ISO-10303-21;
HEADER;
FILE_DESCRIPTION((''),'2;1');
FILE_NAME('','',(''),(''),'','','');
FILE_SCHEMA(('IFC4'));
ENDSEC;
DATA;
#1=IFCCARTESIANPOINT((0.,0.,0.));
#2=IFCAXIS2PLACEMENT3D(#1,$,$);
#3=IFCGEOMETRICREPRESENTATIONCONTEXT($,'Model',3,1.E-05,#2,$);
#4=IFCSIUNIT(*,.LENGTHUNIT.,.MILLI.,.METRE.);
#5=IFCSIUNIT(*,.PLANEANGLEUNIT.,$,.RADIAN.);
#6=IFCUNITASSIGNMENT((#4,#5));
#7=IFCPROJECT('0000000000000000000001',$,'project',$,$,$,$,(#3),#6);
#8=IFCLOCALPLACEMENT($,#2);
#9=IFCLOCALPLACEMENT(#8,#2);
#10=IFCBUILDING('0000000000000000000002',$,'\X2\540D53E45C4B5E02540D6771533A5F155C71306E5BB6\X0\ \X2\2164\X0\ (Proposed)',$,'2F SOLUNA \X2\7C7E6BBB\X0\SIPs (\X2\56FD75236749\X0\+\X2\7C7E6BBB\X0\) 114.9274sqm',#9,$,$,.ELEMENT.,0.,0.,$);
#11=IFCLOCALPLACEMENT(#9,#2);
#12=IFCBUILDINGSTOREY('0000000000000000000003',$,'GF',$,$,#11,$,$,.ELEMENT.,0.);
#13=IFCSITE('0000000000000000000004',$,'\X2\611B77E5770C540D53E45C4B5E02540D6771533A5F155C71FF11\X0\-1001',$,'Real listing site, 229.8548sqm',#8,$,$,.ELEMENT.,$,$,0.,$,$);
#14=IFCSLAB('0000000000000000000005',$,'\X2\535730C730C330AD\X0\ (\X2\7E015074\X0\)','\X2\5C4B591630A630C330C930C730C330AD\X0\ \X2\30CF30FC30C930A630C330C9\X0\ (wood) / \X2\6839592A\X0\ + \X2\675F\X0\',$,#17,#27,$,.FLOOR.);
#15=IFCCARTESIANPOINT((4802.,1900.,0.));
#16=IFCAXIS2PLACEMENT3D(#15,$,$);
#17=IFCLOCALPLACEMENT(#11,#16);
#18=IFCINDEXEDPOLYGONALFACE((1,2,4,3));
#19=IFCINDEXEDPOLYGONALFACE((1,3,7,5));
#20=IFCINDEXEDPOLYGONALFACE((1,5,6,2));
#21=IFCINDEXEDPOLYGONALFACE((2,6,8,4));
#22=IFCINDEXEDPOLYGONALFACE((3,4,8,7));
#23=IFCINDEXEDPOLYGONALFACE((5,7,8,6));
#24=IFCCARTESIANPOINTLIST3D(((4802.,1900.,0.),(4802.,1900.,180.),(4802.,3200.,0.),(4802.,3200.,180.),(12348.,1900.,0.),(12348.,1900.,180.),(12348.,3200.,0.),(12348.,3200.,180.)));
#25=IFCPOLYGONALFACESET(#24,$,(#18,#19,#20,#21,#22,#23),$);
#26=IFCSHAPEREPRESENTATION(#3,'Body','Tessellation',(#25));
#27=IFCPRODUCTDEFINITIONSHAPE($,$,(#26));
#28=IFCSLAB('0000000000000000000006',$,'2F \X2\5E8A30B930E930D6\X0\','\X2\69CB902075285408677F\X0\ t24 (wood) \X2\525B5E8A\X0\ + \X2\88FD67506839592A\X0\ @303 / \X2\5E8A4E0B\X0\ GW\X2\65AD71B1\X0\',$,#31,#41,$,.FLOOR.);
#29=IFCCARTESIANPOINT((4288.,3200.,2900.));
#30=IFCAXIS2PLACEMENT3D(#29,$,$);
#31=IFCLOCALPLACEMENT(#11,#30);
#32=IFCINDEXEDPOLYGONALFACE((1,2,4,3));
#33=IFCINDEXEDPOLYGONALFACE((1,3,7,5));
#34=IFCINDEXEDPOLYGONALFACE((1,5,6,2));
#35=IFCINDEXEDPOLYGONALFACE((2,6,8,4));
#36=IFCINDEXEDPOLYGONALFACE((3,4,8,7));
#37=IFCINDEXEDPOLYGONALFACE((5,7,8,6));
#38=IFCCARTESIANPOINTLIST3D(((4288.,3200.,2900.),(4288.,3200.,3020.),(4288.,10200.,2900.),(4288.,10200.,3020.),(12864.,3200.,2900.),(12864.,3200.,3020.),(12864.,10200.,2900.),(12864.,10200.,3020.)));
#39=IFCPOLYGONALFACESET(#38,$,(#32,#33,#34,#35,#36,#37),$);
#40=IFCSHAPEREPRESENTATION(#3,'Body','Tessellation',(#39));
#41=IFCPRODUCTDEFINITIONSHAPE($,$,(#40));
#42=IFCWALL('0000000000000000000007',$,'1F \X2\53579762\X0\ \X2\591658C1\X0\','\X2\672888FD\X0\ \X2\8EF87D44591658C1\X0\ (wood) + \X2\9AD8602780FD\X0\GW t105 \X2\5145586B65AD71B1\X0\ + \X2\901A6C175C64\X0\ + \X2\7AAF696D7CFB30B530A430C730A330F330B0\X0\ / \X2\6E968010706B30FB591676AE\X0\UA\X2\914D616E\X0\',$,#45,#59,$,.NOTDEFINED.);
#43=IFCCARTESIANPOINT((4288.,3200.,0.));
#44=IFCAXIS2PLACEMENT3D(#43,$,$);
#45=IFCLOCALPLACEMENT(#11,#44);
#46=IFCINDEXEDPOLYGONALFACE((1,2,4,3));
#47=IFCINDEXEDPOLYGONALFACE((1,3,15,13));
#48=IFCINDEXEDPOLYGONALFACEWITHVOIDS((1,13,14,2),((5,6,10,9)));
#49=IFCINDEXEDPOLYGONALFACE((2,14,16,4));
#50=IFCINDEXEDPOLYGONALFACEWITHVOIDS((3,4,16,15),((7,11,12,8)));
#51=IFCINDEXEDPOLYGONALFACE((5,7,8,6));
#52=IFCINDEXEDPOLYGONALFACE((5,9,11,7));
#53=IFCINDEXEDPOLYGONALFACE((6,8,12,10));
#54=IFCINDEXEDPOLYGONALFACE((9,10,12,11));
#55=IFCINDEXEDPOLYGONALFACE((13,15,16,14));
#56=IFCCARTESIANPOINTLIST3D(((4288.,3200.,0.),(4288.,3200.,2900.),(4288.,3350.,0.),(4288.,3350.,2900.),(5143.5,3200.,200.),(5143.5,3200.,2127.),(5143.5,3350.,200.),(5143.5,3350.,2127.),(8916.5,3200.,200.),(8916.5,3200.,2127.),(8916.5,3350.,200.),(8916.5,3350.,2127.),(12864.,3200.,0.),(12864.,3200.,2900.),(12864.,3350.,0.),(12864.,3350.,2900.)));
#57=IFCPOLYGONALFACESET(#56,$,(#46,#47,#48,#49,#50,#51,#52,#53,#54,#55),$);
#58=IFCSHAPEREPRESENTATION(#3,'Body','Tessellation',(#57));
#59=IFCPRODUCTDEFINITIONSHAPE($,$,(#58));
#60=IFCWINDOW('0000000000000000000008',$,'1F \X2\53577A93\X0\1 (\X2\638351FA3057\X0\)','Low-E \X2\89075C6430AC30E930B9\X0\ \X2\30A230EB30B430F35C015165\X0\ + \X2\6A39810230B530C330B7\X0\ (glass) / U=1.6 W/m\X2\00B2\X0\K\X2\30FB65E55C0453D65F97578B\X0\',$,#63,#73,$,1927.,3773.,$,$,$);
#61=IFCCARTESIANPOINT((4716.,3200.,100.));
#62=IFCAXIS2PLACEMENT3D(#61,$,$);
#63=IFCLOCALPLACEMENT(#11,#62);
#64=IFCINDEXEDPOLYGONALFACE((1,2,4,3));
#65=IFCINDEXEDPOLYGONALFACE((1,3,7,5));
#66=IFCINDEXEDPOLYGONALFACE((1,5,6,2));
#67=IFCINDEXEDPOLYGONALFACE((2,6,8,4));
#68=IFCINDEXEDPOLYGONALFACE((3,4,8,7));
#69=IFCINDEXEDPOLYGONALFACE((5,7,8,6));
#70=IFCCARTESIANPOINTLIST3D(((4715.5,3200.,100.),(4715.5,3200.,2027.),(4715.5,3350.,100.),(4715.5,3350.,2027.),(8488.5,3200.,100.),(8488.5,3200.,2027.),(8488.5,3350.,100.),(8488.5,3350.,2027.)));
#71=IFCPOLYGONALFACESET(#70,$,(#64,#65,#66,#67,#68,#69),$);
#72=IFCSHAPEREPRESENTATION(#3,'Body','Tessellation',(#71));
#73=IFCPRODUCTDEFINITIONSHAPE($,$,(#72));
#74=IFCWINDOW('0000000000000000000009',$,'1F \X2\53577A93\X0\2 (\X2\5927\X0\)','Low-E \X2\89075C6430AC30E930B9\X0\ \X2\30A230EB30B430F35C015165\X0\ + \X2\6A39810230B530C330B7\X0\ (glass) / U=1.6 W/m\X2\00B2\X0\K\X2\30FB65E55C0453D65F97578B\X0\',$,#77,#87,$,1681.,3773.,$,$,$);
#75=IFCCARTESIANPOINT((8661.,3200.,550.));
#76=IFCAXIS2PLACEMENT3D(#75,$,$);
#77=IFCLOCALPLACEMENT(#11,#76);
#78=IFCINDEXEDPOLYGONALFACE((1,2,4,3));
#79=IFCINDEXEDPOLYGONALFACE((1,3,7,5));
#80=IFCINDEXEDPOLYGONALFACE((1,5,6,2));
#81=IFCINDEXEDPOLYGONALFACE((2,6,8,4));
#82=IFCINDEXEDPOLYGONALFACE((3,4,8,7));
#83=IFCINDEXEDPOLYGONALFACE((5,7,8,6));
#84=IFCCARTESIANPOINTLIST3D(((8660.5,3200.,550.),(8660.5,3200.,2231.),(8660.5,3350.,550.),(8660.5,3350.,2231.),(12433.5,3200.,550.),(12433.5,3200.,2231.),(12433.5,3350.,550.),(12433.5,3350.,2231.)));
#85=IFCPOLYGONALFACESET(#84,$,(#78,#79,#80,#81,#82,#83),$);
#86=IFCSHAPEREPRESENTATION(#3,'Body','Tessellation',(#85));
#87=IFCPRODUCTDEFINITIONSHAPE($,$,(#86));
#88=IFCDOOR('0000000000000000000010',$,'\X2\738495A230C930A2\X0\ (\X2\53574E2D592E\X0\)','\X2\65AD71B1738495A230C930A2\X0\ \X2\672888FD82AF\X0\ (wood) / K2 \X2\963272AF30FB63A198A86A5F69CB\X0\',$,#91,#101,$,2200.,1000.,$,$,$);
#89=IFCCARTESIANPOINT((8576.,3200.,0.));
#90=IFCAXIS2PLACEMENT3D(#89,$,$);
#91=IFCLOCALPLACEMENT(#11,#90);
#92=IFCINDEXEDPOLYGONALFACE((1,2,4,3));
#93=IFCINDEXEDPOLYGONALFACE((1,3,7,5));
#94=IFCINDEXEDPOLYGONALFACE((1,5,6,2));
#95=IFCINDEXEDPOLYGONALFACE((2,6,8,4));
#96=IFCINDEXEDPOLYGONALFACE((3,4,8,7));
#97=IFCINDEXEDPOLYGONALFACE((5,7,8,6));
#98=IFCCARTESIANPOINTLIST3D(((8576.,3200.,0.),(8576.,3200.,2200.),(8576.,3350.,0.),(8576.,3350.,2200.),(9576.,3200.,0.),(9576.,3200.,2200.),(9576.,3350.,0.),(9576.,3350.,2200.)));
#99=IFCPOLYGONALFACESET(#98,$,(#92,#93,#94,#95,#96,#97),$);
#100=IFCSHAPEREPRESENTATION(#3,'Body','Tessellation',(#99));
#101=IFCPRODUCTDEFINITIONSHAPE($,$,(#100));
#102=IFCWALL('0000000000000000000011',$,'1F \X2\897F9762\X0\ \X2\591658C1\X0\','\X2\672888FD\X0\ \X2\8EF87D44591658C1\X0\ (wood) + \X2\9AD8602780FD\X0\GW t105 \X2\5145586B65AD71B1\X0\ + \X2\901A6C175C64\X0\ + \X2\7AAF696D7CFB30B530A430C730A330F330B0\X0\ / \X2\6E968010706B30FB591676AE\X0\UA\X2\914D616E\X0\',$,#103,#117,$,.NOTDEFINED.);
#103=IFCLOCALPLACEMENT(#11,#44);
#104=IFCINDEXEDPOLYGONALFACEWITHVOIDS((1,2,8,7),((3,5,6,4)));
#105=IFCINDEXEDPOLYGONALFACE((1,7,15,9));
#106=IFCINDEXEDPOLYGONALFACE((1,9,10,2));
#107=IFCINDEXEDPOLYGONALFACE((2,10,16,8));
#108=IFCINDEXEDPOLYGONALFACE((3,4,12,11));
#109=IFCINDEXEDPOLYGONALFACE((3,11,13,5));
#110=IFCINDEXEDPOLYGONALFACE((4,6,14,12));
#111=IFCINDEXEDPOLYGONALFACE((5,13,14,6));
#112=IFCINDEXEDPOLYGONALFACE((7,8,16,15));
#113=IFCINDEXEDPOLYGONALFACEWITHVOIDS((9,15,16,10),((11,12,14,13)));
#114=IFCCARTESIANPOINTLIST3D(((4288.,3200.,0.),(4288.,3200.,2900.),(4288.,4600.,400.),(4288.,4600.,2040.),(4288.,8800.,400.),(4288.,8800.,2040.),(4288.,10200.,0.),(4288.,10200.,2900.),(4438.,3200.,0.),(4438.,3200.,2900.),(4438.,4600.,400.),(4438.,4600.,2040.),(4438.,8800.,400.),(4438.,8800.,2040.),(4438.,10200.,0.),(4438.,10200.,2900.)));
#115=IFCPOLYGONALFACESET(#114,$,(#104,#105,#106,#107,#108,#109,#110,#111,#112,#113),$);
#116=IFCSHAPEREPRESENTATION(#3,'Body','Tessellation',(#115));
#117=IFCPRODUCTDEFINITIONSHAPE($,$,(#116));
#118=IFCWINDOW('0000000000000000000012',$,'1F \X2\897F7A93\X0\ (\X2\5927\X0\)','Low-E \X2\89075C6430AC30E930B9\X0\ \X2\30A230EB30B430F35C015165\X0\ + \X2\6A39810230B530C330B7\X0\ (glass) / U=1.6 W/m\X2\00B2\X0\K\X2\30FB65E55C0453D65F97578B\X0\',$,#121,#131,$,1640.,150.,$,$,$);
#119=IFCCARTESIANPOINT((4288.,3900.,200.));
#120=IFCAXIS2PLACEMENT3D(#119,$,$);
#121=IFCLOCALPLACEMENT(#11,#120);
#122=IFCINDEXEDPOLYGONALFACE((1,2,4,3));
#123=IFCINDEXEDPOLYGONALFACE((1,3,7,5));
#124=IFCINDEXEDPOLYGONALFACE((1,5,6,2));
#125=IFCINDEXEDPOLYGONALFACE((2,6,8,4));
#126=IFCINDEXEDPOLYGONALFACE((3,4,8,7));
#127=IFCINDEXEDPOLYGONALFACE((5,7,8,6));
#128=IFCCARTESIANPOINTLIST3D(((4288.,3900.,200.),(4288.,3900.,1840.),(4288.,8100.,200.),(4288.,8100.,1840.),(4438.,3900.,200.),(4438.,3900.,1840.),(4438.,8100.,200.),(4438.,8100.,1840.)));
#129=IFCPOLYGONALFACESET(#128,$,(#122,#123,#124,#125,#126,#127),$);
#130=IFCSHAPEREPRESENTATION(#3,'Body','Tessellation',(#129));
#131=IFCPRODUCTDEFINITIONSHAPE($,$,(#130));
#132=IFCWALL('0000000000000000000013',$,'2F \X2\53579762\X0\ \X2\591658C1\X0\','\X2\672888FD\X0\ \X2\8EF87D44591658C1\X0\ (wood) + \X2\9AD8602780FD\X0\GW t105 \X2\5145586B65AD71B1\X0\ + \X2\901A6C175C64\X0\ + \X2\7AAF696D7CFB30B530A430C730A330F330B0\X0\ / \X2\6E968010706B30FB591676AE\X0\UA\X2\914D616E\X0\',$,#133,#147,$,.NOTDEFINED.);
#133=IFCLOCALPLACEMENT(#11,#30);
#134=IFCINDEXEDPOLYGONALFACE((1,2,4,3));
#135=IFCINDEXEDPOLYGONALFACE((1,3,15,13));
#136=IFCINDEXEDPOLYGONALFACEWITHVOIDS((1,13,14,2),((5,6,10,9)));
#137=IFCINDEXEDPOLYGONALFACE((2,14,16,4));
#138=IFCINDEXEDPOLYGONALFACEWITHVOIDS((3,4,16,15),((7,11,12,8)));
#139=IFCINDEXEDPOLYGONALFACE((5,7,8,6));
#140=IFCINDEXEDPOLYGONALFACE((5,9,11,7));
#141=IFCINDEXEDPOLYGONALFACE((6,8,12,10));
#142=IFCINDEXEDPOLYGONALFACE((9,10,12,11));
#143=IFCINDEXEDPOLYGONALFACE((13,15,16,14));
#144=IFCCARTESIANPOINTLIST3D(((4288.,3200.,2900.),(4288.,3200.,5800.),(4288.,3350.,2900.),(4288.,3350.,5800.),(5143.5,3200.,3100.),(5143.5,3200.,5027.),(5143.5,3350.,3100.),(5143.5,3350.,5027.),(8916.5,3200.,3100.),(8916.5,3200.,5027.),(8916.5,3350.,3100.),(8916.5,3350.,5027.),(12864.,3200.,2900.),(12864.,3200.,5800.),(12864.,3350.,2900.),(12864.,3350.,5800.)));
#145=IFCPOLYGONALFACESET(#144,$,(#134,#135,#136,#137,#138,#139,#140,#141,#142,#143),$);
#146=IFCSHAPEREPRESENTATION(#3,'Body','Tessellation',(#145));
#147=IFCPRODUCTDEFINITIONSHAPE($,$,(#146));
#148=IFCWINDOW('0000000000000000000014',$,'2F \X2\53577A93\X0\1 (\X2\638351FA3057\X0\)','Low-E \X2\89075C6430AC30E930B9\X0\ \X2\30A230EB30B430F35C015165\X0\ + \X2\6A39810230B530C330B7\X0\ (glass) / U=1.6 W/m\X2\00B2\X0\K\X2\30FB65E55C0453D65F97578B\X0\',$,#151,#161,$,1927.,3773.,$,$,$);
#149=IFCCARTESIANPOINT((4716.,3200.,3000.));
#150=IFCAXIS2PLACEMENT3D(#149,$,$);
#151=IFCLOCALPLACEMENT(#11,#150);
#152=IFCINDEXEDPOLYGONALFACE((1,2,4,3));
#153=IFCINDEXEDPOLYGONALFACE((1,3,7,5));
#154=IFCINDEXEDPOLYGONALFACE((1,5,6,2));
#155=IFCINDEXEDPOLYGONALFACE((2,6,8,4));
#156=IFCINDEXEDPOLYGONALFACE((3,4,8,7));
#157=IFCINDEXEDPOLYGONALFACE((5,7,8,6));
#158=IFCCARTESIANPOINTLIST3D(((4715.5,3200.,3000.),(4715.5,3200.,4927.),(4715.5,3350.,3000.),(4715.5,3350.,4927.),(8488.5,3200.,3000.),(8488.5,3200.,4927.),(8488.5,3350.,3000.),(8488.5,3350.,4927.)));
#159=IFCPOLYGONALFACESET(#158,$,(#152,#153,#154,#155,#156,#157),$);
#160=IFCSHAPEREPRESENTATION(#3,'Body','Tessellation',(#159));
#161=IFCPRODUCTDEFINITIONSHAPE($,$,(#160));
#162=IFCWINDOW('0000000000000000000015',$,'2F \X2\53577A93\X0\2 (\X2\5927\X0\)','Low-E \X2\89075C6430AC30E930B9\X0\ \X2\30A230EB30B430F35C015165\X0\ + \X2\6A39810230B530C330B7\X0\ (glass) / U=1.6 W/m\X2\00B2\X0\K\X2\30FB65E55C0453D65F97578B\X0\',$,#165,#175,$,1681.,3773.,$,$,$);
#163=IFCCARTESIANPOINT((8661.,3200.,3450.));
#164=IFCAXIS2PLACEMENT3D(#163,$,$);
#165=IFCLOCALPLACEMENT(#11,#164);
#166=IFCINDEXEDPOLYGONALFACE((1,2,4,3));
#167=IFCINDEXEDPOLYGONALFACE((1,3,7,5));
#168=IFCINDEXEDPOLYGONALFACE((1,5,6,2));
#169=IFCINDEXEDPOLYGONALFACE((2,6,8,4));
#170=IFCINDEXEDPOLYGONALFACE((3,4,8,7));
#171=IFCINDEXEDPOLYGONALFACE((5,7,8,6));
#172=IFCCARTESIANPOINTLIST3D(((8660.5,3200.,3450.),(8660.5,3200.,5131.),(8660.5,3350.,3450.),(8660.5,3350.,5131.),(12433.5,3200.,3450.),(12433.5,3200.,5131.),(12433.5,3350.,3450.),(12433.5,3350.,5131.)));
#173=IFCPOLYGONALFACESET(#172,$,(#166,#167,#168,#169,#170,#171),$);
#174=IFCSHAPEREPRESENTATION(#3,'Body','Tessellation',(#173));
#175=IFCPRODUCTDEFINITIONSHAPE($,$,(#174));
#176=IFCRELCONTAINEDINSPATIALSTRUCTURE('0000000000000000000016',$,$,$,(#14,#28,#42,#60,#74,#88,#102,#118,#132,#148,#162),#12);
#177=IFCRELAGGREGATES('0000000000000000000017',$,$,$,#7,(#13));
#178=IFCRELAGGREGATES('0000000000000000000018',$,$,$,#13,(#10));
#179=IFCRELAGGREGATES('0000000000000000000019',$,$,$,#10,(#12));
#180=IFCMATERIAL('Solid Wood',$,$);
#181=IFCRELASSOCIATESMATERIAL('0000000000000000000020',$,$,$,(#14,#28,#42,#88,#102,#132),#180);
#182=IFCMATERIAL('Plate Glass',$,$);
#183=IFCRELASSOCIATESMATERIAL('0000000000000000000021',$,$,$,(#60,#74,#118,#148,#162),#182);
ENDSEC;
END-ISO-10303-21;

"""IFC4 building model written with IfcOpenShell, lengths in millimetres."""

from ifc_helpers import new_model, si_unit, frame, frame_2d, origin, place, context, project, spatial, rectangle, extrude, material, element, fill, save


model = new_model("IFC4")

# Units and contexts
model_context = context("Model", 3, precision=1e-05, world=origin())
ifc_project = project(units=[si_unit("LENGTHUNIT", "METRE", prefix="MILLI"), si_unit("PLANEANGLEUNIT", "RADIAN")], contexts=[model_context])

# Site, building, storey
site_placement = place(None, origin())
site = spatial("IfcSite", under=ifc_project, at=site_placement, Name="愛知県名古屋市名東区引山１-1001", ObjectType="Real listing site, 229.8548sqm", CompositionType="ELEMENT", RefElevation=0.0)
building_placement = place(site_placement, origin())
building = spatial("IfcBuilding", under=site, at=building_placement, Name="名古屋市名東区引山の家 Ⅴ (Proposed)", ObjectType="2F SOLUNA 籾殻SIPs (国産杉+籾殻) 114.9274sqm", CompositionType="ELEMENT", ElevationOfRefHeight=0.0, ElevationOfTerrain=0.0)
storey_placement = place(building_placement, origin())
storey = spatial("IfcBuildingStorey", under=building, at=storey_placement, Name="GF", CompositionType="ELEMENT", Elevation=0.0)

# Slabs
ifc_material_1 = material(Name="Solid Wood")
slab_1_placement = place(storey_placement, frame((4802.0, 1900.0, 0.0)))
element("IfcSlab", 1, at=slab_1_placement, inside=storey, material=ifc_material_1, Name="南デッキ (縁側)", Description="屋外ウッドデッキ ハードウッド (wood) / 根太 + 束", PredefinedType="FLOOR", context=model_context, shape_type="SweptSolid", body=[
    extrude(rectangle(XDim=7546.0, YDim=1300.0, at=frame_2d((3773.0, 650.0))), frame((4802.0, 1900.0, 0.0)), (0.0, 0.0, 1.0), 180.0),
])
slab_2_placement = place(storey_placement, frame((4288.0, 3200.0, 2900.0)))
element("IfcSlab", 2, at=slab_2_placement, inside=storey, material=ifc_material_1, Name="2F 床スラブ", Description="構造用合板 t24 (wood) 剛床 + 製材根太 @303 / 床下 GW断熱", PredefinedType="FLOOR", context=model_context, shape_type="SweptSolid", body=[
    extrude(rectangle(XDim=8576.0, YDim=7000.0, at=frame_2d((4288.0, 3500.0))), frame((4288.0, 3200.0, 2900.0)), (0.0, 0.0, 1.0), 120.0),
])

# Wall, openings, windows, door
wall_1_placement = place(storey_placement, frame((4288.0, 3200.0, 0.0)))
wall_1 = element("IfcWall", 3, at=wall_1_placement, inside=storey, material=ifc_material_1, Name="1F 南面 外壁", Description="木製 軸組外壁 (wood) + 高性能GW t105 充填断熱 + 通気層 + 窯業系サイディング / 準耐火・外皮UA配慮", PredefinedType="NOTDEFINED", context=model_context, shape_type="SweptSolid", body=[
    extrude(rectangle(XDim=8576.0, YDim=150.0, at=frame_2d((4288.0, 75.0))), frame((4288.0, 3200.0, 0.0)), (0.0, 0.0, 1.0), 2900.0),
])
opening_1_placement = place(storey_placement, frame((4716.0, 3200.0, 100.0)))
opening_1 = element("IfcOpeningElement", 4, at=opening_1_placement, cuts=wall_1, PredefinedType="NOTDEFINED", context=model_context, shape_type="SweptSolid", body=[
    extrude(rectangle(XDim=3773.0, YDim=150.0, at=frame_2d((1886.0, 75.0))), frame((4716.0, 3200.0, 100.0)), (0.0, 0.0, 1.0), 1927.0),
])
opening_2_placement = place(storey_placement, frame((8661.0, 3200.0, 550.0)))
opening_2 = element("IfcOpeningElement", 5, at=opening_2_placement, cuts=wall_1, PredefinedType="NOTDEFINED", context=model_context, shape_type="SweptSolid", body=[
    extrude(rectangle(XDim=3773.0, YDim=150.0, at=frame_2d((1886.0, 75.0))), frame((8661.0, 3200.0, 550.0)), (0.0, 0.0, 1.0), 1681.0),
])
opening_3_placement = place(storey_placement, frame((8576.0, 3200.0, 0.0)))
opening_3 = element("IfcOpeningElement", 6, at=opening_3_placement, cuts=wall_1, PredefinedType="NOTDEFINED", context=model_context, shape_type="SweptSolid", body=[
    extrude(rectangle(XDim=1000.0, YDim=150.0, at=frame_2d((500.0, 75.0))), frame((8576.0, 3200.0, 0.0)), (0.0, 0.0, 1.0), 2200.0),
])
ifc_material_2 = material(Name="Plate Glass")
window_1_placement = place(storey_placement, frame((4716.0, 3200.0, 100.0)))
window_1 = element("IfcWindow", 7, at=window_1_placement, inside=storey, material=ifc_material_2, Name="1F 南窓1 (掃出し)", Description="Low-E 複層ガラス アルゴン封入 + 樹脂サッシ (glass) / U=1.6 W/m²K・日射取得型", OverallHeight=1927.0, OverallWidth=3773.0, context=model_context, shape_type="SweptSolid", body=[
    extrude(rectangle(XDim=3773.0, YDim=150.0, at=frame_2d((1886.0, 75.0))), frame((4716.0, 3200.0, 100.0)), (0.0, 0.0, 1.0), 1927.0),
])
fill(opening_1, window_1)
window_2_placement = place(storey_placement, frame((8661.0, 3200.0, 550.0)))
window_2 = element("IfcWindow", 8, at=window_2_placement, inside=storey, material=ifc_material_2, Name="1F 南窓2 (大)", Description="Low-E 複層ガラス アルゴン封入 + 樹脂サッシ (glass) / U=1.6 W/m²K・日射取得型", OverallHeight=1681.0, OverallWidth=3773.0, context=model_context, shape_type="SweptSolid", body=[
    extrude(rectangle(XDim=3773.0, YDim=150.0, at=frame_2d((1886.0, 75.0))), frame((8661.0, 3200.0, 550.0)), (0.0, 0.0, 1.0), 1681.0),
])
fill(opening_2, window_2)
door_placement = place(storey_placement, frame((8576.0, 3200.0, 0.0)))
door = element("IfcDoor", 9, at=door_placement, inside=storey, material=ifc_material_1, Name="玄関ドア (南中央)", Description="断熱玄関ドア 木製芯 (wood) / K2 防犯・採風機構", OverallHeight=2200.0, OverallWidth=1000.0, context=model_context, shape_type="SweptSolid", body=[
    extrude(rectangle(XDim=1000.0, YDim=150.0, at=frame_2d((500.0, 75.0))), frame((8576.0, 3200.0, 0.0)), (0.0, 0.0, 1.0), 2200.0),
])
fill(opening_3, door)

# Wall, opening, window
wall_2_placement = place(storey_placement, frame((4288.0, 3200.0, 0.0)))
wall_2 = element("IfcWall", 10, at=wall_2_placement, inside=storey, material=ifc_material_1, Name="1F 西面 外壁", Description="木製 軸組外壁 (wood) + 高性能GW t105 充填断熱 + 通気層 + 窯業系サイディング / 準耐火・外皮UA配慮", PredefinedType="NOTDEFINED", context=model_context, shape_type="SweptSolid", body=[
    extrude(rectangle(XDim=150.0, YDim=7000.0, at=frame_2d((75.0, 3500.0))), frame((4288.0, 3200.0, 0.0)), (0.0, 0.0, 1.0), 2900.0),
])
opening_4_placement = place(storey_placement, frame((4288.0, 3900.0, 200.0)))
opening_4 = element("IfcOpeningElement", 11, at=opening_4_placement, cuts=wall_2, PredefinedType="NOTDEFINED", context=model_context, shape_type="SweptSolid", body=[
    extrude(rectangle(XDim=150.0, YDim=4200.0, at=frame_2d((75.0, 2100.0))), frame((4288.0, 3900.0, 200.0)), (0.0, 0.0, 1.0), 1640.0),
])
window_3_placement = place(storey_placement, frame((4288.0, 3900.0, 200.0)))
window_3 = element("IfcWindow", 12, at=window_3_placement, inside=storey, material=ifc_material_2, Name="1F 西窓 (大)", Description="Low-E 複層ガラス アルゴン封入 + 樹脂サッシ (glass) / U=1.6 W/m²K・日射取得型", OverallHeight=1640.0, OverallWidth=150.0, context=model_context, shape_type="SweptSolid", body=[
    extrude(rectangle(XDim=150.0, YDim=4200.0, at=frame_2d((75.0, 2100.0))), frame((4288.0, 3900.0, 200.0)), (0.0, 0.0, 1.0), 1640.0),
])
fill(opening_4, window_3)

# Wall, openings, windows
wall_3_placement = place(storey_placement, frame((4288.0, 3200.0, 2900.0)))
wall_3 = element("IfcWall", 13, at=wall_3_placement, inside=storey, material=ifc_material_1, Name="2F 南面 外壁", Description="木製 軸組外壁 (wood) + 高性能GW t105 充填断熱 + 通気層 + 窯業系サイディング / 準耐火・外皮UA配慮", PredefinedType="NOTDEFINED", context=model_context, shape_type="SweptSolid", body=[
    extrude(rectangle(XDim=8576.0, YDim=150.0, at=frame_2d((4288.0, 75.0))), frame((4288.0, 3200.0, 2900.0)), (0.0, 0.0, 1.0), 2900.0),
])
opening_5_placement = place(storey_placement, frame((4716.0, 3200.0, 3000.0)))
opening_5 = element("IfcOpeningElement", 14, at=opening_5_placement, cuts=wall_3, PredefinedType="NOTDEFINED", context=model_context, shape_type="SweptSolid", body=[
    extrude(rectangle(XDim=3773.0, YDim=150.0, at=frame_2d((1886.0, 75.0))), frame((4716.0, 3200.0, 3000.0)), (0.0, 0.0, 1.0), 1927.0),
])
opening_6_placement = place(storey_placement, frame((8661.0, 3200.0, 3450.0)))
opening_6 = element("IfcOpeningElement", 15, at=opening_6_placement, cuts=wall_3, PredefinedType="NOTDEFINED", context=model_context, shape_type="SweptSolid", body=[
    extrude(rectangle(XDim=3773.0, YDim=150.0, at=frame_2d((1886.0, 75.0))), frame((8661.0, 3200.0, 3450.0)), (0.0, 0.0, 1.0), 1681.0),
])
window_4_placement = place(storey_placement, frame((4716.0, 3200.0, 3000.0)))
window_4 = element("IfcWindow", 16, at=window_4_placement, inside=storey, material=ifc_material_2, Name="2F 南窓1 (掃出し)", Description="Low-E 複層ガラス アルゴン封入 + 樹脂サッシ (glass) / U=1.6 W/m²K・日射取得型", OverallHeight=1927.0, OverallWidth=3773.0, context=model_context, shape_type="SweptSolid", body=[
    extrude(rectangle(XDim=3773.0, YDim=150.0, at=frame_2d((1886.0, 75.0))), frame((4716.0, 3200.0, 3000.0)), (0.0, 0.0, 1.0), 1927.0),
])
fill(opening_5, window_4)
window_5_placement = place(storey_placement, frame((8661.0, 3200.0, 3450.0)))
window_5 = element("IfcWindow", 17, at=window_5_placement, inside=storey, material=ifc_material_2, Name="2F 南窓2 (大)", Description="Low-E 複層ガラス アルゴン封入 + 樹脂サッシ (glass) / U=1.6 W/m²K・日射取得型", OverallHeight=1681.0, OverallWidth=3773.0, context=model_context, shape_type="SweptSolid", body=[
    extrude(rectangle(XDim=3773.0, YDim=150.0, at=frame_2d((1886.0, 75.0))), frame((8661.0, 3200.0, 3450.0)), (0.0, 0.0, 1.0), 1681.0),
])
fill(opening_6, window_5)

save(model, "model.ifc")
